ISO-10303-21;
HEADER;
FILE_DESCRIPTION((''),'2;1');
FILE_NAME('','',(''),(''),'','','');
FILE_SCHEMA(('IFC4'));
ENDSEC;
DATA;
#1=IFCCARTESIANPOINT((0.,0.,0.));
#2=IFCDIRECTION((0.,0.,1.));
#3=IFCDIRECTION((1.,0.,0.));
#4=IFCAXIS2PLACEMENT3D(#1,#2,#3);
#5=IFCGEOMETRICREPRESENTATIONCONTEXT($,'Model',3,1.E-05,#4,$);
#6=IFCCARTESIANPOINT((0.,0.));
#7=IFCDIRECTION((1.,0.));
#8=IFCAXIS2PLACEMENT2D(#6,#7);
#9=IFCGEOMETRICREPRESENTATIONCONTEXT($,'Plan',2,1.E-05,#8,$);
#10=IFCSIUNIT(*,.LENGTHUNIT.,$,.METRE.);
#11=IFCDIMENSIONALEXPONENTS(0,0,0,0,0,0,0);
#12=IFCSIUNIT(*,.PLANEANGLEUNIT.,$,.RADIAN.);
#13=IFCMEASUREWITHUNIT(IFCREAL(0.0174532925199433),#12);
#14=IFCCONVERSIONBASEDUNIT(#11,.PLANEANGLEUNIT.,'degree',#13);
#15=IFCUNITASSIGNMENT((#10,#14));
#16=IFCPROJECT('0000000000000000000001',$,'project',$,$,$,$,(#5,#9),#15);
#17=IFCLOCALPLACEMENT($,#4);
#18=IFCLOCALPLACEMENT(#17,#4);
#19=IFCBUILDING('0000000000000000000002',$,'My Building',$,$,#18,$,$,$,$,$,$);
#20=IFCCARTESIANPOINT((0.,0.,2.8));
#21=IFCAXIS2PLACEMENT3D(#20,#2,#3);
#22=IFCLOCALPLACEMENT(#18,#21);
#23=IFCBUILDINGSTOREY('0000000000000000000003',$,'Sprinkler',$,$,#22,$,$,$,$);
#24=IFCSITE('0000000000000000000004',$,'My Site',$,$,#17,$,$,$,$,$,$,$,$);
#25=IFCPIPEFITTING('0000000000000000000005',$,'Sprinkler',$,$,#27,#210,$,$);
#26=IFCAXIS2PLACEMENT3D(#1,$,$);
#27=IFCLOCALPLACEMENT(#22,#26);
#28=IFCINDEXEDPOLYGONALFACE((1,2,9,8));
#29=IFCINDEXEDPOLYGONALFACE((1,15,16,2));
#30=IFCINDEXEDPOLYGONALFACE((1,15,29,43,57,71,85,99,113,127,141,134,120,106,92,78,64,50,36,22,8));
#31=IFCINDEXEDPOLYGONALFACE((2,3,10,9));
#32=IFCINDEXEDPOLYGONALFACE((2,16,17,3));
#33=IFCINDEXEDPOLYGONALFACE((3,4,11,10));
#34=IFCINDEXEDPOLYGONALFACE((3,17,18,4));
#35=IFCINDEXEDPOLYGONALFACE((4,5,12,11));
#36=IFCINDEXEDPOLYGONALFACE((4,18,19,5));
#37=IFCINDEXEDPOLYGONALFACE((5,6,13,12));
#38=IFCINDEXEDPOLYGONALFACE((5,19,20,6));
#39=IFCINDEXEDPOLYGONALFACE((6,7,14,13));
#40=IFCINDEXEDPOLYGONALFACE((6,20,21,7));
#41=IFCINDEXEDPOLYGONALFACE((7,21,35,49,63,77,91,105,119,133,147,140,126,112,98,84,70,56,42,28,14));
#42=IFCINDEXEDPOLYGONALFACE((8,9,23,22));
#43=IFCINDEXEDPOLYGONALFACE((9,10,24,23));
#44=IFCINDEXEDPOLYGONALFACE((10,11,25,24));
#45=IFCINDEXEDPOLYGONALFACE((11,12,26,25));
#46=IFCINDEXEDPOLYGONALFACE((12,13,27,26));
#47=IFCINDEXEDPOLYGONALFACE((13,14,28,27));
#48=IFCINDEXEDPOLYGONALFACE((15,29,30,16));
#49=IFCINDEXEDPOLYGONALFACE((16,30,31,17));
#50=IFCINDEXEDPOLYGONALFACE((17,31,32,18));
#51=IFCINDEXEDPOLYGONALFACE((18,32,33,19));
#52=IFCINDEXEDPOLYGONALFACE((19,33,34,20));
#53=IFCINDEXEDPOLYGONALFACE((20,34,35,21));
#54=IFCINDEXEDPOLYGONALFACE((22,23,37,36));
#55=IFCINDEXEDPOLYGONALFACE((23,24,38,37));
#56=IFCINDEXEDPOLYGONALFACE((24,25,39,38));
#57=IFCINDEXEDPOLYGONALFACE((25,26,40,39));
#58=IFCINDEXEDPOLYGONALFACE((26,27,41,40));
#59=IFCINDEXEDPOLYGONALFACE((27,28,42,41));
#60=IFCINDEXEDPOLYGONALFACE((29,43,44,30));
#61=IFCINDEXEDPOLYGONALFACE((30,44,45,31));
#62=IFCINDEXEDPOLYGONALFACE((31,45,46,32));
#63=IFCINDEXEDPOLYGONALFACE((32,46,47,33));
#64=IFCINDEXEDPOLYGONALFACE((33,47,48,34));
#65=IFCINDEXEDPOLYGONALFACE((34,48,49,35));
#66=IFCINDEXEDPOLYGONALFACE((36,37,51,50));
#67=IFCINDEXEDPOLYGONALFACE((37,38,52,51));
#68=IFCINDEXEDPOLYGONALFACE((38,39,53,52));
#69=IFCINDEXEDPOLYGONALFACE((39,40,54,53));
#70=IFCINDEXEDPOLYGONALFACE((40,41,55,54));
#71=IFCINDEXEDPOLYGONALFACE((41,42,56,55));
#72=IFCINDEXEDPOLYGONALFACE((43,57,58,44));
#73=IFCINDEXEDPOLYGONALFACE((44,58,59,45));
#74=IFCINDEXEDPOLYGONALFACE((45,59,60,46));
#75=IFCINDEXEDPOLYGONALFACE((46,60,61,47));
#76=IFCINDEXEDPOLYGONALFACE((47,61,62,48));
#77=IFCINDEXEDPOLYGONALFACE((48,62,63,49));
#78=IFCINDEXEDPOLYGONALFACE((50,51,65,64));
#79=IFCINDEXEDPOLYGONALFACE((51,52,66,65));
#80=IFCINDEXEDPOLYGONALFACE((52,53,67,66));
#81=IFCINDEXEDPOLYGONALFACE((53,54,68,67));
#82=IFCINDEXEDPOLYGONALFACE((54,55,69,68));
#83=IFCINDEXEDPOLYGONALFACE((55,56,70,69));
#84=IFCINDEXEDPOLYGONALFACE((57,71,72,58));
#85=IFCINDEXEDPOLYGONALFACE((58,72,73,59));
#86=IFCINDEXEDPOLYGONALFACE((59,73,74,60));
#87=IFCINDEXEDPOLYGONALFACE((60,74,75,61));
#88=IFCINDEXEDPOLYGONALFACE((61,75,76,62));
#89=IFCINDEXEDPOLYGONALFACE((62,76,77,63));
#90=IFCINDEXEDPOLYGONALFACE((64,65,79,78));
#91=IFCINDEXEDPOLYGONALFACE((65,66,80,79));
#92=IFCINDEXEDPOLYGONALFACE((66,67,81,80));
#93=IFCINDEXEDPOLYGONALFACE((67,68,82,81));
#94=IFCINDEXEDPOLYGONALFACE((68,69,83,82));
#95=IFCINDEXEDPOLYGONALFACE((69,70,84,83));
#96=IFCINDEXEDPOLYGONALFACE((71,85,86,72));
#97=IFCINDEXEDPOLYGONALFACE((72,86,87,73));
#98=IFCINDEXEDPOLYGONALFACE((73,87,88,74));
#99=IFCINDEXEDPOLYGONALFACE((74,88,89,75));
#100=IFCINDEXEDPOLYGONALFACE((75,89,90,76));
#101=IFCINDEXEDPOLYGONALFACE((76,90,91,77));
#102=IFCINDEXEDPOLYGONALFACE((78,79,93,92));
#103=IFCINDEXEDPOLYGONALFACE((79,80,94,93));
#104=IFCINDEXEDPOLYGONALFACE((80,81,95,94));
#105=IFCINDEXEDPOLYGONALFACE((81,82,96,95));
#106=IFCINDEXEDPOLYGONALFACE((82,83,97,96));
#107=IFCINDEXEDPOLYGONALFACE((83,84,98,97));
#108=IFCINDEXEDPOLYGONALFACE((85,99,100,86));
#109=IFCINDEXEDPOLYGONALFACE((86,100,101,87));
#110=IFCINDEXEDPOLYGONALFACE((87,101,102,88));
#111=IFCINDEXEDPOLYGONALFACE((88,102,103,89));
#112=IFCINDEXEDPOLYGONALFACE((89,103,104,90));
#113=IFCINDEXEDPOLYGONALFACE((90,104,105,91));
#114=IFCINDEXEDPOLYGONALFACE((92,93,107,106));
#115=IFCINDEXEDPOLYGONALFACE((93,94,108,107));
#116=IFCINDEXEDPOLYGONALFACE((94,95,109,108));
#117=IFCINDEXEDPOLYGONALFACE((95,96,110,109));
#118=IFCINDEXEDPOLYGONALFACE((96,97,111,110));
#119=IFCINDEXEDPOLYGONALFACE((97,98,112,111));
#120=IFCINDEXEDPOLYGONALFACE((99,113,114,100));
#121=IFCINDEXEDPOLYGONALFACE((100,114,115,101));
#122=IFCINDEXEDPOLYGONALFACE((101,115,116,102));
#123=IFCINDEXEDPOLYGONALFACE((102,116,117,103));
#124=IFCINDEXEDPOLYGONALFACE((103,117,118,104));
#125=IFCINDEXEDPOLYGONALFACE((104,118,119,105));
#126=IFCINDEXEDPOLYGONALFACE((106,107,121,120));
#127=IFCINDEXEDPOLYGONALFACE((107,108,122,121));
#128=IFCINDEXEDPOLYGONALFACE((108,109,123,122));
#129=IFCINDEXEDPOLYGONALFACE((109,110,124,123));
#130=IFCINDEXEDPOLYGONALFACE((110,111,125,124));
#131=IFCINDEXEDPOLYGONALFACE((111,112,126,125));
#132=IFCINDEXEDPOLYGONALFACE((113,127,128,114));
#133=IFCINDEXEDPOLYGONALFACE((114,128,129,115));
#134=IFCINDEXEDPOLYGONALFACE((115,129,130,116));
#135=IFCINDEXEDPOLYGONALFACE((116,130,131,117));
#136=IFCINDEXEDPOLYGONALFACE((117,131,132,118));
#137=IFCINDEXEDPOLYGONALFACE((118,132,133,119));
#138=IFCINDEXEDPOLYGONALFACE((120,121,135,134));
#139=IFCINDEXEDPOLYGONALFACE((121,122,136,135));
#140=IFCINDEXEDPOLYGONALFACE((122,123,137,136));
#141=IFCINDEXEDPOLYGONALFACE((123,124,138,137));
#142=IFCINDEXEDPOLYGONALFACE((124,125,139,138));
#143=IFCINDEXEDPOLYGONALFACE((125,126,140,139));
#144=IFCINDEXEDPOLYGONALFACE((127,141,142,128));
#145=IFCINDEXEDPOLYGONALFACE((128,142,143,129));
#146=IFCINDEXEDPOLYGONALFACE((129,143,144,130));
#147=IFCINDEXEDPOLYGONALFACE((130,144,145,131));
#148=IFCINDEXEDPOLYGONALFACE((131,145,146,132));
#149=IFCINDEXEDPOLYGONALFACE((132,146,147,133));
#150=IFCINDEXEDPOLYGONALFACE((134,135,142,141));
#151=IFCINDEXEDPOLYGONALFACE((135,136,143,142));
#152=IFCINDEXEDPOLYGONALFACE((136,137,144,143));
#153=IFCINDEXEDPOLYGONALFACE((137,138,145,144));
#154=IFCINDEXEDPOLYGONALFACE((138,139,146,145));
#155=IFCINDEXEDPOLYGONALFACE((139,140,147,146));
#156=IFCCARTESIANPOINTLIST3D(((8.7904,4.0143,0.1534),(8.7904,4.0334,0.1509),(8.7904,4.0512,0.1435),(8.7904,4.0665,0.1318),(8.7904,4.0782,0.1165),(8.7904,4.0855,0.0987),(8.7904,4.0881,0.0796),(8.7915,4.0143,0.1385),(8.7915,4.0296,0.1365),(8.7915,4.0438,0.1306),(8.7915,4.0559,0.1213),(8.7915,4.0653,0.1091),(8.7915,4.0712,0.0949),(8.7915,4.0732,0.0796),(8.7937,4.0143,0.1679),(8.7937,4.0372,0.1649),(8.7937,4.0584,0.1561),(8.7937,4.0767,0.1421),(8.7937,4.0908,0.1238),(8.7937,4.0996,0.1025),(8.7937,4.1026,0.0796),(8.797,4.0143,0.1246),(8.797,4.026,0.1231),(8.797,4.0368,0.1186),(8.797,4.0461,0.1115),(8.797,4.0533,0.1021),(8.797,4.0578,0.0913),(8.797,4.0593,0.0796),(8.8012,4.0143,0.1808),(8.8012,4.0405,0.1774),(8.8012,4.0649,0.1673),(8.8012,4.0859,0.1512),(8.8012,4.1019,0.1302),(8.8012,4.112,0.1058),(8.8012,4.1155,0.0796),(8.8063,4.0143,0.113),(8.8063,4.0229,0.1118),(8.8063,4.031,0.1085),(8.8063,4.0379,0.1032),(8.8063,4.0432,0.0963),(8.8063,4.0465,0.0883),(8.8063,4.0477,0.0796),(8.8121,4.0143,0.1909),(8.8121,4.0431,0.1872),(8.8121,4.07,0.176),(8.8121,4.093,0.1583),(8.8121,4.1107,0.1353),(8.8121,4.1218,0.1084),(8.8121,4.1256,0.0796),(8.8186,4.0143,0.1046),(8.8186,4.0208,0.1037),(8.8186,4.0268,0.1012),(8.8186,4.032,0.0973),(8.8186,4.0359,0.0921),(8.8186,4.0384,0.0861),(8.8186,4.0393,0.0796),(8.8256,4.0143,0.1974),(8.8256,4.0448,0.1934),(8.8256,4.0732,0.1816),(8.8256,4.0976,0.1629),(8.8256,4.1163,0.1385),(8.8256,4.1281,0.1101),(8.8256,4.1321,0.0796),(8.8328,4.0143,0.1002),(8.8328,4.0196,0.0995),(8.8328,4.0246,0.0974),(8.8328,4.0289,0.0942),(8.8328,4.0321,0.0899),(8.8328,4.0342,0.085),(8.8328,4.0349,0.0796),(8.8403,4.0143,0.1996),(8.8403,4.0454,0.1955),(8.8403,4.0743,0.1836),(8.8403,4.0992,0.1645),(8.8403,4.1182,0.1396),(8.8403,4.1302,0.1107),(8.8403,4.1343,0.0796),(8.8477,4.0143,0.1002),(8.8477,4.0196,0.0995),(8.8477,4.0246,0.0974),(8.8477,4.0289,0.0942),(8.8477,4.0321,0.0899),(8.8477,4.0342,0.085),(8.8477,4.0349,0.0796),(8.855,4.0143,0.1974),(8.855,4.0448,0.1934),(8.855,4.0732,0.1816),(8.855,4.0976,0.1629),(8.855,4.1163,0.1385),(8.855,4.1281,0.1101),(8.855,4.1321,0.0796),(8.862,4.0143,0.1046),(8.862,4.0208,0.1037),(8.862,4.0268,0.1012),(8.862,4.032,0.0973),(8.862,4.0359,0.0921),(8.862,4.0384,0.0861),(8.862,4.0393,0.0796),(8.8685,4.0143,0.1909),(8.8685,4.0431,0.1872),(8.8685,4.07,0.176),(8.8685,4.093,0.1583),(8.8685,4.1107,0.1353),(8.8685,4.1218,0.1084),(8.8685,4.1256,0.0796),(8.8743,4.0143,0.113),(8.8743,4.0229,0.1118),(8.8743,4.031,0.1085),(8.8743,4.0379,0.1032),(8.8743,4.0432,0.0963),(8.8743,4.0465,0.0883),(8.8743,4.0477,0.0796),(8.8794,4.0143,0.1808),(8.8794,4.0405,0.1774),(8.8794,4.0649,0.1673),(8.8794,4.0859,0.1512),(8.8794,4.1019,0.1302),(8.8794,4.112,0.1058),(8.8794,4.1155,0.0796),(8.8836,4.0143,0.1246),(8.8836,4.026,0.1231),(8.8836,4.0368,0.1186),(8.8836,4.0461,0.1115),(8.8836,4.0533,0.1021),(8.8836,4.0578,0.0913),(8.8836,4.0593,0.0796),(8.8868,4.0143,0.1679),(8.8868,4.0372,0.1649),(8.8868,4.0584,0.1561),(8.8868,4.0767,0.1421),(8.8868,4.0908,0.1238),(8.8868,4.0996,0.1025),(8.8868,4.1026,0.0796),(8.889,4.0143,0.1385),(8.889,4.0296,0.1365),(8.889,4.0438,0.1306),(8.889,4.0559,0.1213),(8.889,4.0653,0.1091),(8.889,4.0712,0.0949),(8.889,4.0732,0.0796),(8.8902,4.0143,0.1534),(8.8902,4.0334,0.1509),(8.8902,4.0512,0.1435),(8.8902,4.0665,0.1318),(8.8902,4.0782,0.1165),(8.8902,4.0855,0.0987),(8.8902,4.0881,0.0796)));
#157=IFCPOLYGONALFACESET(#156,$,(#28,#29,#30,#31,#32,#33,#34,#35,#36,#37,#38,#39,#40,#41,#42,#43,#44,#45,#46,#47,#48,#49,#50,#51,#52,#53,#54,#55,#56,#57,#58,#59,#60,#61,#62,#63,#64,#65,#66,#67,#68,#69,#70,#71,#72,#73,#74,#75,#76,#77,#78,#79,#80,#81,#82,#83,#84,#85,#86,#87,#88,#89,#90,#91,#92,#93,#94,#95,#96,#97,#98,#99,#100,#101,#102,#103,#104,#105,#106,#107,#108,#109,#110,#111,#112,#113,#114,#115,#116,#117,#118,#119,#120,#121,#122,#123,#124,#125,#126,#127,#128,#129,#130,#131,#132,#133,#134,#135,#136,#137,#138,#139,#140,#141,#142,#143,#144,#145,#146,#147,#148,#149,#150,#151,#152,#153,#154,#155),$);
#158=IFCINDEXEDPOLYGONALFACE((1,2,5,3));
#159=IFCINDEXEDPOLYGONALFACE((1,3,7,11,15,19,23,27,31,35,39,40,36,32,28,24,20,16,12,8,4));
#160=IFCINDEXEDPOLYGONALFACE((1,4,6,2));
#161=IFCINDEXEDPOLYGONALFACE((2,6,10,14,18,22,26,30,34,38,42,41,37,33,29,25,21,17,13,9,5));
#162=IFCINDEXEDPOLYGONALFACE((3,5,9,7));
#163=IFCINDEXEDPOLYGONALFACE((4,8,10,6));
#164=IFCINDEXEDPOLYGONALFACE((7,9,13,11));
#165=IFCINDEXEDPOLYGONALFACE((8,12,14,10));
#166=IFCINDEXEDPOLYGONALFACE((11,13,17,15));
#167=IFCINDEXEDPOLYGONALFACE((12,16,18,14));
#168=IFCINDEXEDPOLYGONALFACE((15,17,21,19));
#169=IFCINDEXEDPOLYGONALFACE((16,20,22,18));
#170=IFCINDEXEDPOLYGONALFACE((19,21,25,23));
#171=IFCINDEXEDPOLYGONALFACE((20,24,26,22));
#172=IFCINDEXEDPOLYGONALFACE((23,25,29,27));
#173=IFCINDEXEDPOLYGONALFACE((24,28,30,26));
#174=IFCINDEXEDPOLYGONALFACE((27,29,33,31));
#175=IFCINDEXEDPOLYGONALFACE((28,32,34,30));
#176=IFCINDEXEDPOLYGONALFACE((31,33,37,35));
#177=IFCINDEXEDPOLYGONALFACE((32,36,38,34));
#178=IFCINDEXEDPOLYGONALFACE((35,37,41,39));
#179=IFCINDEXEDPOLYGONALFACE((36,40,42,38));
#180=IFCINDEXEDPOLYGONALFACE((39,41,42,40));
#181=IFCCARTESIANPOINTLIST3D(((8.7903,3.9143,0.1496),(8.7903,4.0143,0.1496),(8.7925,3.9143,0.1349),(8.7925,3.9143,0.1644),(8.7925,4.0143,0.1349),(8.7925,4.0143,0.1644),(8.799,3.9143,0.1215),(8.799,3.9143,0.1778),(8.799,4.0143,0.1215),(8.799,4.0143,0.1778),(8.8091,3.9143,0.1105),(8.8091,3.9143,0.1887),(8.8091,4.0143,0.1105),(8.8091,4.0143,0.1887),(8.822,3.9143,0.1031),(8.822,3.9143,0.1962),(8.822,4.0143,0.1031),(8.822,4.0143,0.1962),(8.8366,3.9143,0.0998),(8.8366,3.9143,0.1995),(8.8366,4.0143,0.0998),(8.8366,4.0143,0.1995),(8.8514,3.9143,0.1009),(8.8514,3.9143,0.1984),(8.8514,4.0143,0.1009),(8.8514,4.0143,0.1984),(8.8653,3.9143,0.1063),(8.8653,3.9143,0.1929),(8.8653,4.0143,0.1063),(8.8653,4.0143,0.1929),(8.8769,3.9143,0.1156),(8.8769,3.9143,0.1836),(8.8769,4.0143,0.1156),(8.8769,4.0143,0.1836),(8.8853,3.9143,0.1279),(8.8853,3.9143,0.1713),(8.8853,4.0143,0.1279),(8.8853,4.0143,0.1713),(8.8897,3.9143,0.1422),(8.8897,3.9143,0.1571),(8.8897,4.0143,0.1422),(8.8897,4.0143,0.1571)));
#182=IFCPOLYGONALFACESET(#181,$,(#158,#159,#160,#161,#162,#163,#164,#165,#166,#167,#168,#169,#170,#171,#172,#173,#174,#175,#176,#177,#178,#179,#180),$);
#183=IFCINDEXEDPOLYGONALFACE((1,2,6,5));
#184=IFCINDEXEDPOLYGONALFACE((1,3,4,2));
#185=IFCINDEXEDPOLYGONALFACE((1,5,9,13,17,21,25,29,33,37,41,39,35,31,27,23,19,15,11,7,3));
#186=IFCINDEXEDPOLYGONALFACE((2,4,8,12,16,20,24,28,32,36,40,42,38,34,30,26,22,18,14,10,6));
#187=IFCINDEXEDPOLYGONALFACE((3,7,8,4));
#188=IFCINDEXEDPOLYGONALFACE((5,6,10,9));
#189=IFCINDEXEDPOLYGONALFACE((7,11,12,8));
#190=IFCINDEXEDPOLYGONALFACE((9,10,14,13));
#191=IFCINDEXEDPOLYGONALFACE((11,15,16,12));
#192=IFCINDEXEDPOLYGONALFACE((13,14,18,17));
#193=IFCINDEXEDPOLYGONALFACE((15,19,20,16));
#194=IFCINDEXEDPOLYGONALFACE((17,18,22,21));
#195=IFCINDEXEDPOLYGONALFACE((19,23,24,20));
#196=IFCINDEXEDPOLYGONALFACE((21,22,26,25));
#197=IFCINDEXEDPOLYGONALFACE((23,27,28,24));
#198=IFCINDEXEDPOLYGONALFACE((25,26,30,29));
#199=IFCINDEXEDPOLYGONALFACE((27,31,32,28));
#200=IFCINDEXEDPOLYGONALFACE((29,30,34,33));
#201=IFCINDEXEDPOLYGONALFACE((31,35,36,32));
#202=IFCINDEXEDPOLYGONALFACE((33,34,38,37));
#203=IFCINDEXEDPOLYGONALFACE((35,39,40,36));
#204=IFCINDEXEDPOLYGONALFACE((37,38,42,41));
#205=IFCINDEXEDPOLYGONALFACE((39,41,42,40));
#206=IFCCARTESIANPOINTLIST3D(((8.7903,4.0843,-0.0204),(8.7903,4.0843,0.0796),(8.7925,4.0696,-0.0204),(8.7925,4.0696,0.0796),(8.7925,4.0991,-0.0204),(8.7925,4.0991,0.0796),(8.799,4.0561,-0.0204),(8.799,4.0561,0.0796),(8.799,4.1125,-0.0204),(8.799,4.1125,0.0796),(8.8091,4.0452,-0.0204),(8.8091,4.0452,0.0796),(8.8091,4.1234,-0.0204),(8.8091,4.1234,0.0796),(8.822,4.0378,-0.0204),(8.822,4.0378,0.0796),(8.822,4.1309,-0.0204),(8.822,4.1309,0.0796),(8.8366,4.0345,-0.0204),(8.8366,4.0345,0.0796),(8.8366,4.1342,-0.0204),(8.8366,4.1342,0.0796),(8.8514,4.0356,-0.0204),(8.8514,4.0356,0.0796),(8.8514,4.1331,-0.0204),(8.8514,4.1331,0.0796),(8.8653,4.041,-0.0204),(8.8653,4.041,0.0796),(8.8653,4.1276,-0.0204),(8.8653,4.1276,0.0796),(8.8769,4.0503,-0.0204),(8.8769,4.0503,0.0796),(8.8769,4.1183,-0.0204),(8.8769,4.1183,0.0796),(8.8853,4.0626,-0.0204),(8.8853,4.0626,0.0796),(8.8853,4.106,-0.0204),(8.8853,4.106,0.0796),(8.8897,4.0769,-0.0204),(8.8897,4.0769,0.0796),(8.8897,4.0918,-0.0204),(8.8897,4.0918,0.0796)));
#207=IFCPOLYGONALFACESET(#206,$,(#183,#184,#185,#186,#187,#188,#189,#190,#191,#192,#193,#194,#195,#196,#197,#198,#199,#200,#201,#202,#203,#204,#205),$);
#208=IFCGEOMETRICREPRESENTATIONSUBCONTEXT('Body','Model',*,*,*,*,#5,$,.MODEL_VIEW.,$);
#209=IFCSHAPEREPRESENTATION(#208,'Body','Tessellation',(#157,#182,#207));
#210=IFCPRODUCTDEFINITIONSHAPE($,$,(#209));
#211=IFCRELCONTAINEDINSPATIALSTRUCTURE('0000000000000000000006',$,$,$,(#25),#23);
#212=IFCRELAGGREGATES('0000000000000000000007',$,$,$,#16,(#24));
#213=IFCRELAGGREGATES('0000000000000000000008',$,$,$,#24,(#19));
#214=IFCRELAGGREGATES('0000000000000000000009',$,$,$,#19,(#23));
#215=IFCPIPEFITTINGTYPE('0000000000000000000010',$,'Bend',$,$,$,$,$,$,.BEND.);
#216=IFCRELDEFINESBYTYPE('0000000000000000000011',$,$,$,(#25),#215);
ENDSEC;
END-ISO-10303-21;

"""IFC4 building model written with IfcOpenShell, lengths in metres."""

from ifc_helpers import new_model, entity, si_unit, converted_unit, frame, origin_with_axes, origin_2d_with_axis, place, context, subcontext, project, spatial, circle, extrude, source, transform, mapped, type_object, type_shapes, element, save


model = new_model("IFC4")

# Units and contexts
model_context = context("Model", 3, precision=1e-05, world=origin_with_axes())
plan_context = context("Plan", 2, precision=1e-05, world=origin_2d_with_axis())
body_context = subcontext(model_context, "Body", "Model", "MODEL_VIEW")
ifc_project = project(units=[si_unit("LENGTHUNIT", "METRE"), converted_unit("PLANEANGLEUNIT", "degree", entity("IfcReal", 0.0174532925199433), si_unit("PLANEANGLEUNIT", "RADIAN"), dimensions=[0, 0, 0, 0, 0, 0, 0])], contexts=[model_context, plan_context])

# Site, building, storey
site_placement = place(None, origin_with_axes())
site = spatial("IfcSite", under=ifc_project, at=site_placement, Name="My Site")
building_placement = place(site_placement, origin_with_axes())
building = spatial("IfcBuilding", under=site, at=building_placement, Name="My Building")
storey_placement = place(building_placement, frame((0.0, 0.0, 2.8), z_axis=(0.0, 0.0, 1.0), x_axis=(1.0, 0.0, 0.0)))
storey = spatial("IfcBuildingStorey", under=building, at=storey_placement, Name="Sprinkler")

# Pipe fitting
pipe_fitting_type_1 = type_object("IfcPipeFittingType", Name="Bend", PredefinedType="BEND")
shared_shape_1 = source(origin_with_axes(), body_context, "Body", "SolidModel", [
    entity("IfcSweptDiskSolid", entity("IfcIndexedPolyCurve", entity("IfcCartesianPointList3D", [[0.0, 0.0, 0.1], [0.0, -0.0205, 0.1495], [0.0, -0.07, 0.17]]), [entity("IfcArcIndex", [1, 2, 3])]), 0.05),
    extrude(circle(Radius=0.05), origin_with_axes(), (0.0, 0.0, 1.0), 0.1),
    extrude(circle(Radius=0.05), frame((0.0, -0.07, 0.17), z_axis=(0.0, -1.0, 0.0), x_axis=(1.0, 0.0, 0.0)), (0.0, 0.0, 1.0), 0.1),
])
type_shapes(pipe_fitting_type_1, [shared_shape_1])
for number, where, z_axis, x_axis, name in (
    (1, (8.8403, 3.9143, 0.1496), (0.0, 1.0, 0.0), (-1.0, 0.0, 0.0), "Sprinkler"),
):
    element("IfcPipeFitting", number, at=place(storey_placement, frame(where, z_axis=z_axis, x_axis=x_axis)), inside=storey, type_object=pipe_fitting_type_1, Name=name, context=body_context, shape_type="MappedRepresentation", body=[
        mapped(shared_shape_1, transform((0.0, 0.0, 0.0), x_axis=(1.0, 0.0, 0.0), y_axis=(0.0, 1.0, 0.0), z_axis=(0.0, 0.0, 1.0), scale=1.0)),
    ])

save(model, "model.ifc")
